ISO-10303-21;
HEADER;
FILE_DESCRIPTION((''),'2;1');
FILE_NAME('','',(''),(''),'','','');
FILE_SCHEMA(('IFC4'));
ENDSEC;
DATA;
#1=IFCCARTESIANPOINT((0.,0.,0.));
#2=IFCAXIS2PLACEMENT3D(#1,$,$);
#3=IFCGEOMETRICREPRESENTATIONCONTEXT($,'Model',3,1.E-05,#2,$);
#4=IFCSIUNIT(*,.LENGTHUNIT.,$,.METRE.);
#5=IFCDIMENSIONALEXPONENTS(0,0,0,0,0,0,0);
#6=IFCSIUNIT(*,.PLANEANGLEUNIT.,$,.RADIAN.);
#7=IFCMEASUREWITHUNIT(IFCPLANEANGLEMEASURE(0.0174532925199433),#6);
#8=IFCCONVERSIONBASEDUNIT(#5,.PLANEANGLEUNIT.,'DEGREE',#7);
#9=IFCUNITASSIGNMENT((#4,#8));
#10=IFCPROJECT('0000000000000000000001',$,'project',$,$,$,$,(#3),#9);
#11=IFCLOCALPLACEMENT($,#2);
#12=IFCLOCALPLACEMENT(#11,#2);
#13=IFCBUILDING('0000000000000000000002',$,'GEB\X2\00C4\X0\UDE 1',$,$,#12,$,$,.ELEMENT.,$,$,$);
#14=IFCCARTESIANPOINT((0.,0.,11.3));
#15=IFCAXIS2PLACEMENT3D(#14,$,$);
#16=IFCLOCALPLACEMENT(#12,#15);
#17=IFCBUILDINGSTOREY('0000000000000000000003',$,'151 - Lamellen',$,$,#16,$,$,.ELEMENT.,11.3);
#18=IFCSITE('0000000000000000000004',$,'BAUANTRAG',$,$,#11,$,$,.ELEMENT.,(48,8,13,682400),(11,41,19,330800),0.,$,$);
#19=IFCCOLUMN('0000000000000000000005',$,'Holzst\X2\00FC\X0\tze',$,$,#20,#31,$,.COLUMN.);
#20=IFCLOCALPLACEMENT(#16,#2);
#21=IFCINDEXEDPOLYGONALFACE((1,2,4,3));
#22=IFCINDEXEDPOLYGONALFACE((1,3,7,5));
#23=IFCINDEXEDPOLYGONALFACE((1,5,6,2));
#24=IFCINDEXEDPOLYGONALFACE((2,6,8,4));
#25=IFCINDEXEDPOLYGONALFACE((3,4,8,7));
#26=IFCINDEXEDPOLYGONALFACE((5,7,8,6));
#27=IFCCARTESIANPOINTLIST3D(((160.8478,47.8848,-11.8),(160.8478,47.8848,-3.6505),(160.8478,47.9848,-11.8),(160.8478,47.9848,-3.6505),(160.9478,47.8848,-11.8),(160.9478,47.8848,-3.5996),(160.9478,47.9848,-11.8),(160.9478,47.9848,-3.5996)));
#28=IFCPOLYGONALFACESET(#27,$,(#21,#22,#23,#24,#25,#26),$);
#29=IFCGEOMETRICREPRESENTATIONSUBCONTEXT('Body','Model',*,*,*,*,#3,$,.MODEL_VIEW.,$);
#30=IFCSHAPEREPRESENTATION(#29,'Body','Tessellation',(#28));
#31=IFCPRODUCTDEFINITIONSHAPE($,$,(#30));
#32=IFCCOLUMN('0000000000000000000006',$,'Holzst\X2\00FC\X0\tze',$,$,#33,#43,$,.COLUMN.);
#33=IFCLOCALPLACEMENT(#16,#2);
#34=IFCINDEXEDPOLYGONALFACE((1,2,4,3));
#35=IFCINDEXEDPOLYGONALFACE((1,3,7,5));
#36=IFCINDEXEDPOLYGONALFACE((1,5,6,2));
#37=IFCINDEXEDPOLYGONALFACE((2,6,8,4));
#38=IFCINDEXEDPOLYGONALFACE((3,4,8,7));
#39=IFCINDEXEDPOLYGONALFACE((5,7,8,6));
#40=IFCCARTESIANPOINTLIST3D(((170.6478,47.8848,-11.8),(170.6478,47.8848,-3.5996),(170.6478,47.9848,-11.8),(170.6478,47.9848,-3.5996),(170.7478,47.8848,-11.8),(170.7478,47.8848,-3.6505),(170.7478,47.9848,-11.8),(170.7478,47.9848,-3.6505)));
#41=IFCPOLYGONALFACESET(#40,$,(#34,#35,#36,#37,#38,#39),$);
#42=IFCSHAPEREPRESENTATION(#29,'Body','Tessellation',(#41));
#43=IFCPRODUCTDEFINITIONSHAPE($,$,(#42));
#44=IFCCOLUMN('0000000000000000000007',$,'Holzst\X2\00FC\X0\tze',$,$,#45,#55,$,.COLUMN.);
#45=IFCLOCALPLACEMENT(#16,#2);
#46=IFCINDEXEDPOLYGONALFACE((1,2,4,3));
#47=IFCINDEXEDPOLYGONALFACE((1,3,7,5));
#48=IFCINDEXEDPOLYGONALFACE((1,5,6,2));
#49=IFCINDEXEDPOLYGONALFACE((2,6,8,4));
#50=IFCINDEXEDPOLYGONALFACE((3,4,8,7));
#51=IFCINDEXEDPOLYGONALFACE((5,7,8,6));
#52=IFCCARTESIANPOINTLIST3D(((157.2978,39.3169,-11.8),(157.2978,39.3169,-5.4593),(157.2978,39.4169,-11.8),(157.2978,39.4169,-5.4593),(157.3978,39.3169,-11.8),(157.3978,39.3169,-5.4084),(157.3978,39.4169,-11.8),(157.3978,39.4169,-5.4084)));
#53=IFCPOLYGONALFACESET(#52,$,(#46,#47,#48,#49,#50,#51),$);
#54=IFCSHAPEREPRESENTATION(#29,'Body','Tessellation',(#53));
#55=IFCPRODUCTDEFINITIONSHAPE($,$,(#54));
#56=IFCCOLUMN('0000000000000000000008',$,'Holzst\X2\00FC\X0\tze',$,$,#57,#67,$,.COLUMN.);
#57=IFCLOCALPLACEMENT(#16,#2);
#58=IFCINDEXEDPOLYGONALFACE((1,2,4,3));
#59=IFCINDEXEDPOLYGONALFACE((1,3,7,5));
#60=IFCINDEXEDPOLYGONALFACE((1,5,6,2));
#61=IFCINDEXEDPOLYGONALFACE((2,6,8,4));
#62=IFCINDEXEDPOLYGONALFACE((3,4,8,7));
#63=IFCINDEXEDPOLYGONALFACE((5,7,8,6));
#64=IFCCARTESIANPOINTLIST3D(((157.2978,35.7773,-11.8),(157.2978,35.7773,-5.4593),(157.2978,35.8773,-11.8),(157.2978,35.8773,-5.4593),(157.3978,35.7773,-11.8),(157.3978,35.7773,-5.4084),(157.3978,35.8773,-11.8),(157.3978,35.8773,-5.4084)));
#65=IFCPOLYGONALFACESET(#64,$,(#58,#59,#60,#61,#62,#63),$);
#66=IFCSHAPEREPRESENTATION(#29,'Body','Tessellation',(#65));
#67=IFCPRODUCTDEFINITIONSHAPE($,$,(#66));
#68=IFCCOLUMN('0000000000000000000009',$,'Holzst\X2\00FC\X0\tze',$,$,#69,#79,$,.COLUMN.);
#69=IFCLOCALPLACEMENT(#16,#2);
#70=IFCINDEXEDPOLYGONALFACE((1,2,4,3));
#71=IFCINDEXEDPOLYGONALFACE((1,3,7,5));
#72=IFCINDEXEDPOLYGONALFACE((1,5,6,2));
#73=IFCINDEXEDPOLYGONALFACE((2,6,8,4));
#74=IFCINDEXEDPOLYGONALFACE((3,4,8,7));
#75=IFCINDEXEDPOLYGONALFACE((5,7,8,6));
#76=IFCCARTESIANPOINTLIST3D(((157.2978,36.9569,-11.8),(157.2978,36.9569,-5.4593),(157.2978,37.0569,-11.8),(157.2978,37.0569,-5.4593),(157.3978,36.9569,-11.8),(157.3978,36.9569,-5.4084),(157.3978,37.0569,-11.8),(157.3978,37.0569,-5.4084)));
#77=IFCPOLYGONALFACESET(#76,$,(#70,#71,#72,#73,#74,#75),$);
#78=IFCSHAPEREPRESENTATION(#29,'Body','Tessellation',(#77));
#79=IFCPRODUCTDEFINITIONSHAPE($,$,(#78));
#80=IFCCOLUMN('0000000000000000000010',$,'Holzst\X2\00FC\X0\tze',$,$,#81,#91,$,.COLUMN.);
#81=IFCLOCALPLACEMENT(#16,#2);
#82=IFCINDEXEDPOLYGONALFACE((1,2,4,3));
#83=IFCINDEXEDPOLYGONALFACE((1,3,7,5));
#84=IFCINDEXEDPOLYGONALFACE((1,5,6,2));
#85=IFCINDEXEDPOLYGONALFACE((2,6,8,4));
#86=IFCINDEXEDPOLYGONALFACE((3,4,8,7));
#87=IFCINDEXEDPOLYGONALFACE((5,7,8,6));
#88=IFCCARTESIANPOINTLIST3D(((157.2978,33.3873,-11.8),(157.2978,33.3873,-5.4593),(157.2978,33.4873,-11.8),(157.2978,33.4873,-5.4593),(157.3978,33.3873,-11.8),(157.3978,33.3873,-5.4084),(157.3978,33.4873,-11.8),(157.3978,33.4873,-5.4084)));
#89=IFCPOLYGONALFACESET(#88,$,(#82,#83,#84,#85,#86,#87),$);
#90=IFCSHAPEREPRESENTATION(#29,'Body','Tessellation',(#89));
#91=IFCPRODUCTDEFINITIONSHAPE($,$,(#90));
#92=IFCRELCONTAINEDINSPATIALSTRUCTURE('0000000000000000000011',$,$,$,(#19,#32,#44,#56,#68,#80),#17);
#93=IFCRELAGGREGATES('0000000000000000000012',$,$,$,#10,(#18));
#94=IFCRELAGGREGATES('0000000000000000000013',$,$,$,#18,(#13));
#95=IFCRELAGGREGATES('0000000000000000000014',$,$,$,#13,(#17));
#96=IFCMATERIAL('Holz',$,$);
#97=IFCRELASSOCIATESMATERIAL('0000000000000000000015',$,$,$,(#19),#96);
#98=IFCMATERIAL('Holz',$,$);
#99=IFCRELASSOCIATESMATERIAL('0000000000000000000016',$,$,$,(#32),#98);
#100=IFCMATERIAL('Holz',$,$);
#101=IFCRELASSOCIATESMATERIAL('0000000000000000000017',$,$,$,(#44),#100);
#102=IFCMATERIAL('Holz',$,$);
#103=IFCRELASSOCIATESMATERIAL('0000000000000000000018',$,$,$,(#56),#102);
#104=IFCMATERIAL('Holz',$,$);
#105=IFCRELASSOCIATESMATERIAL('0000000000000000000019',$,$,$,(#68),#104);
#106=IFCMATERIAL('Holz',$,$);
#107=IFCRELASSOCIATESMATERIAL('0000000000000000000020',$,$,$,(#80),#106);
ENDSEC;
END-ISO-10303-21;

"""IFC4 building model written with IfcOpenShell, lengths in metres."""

from ifc_helpers import new_model, entity, si_unit, converted_unit, frame, frame_2d, origin, origin_with_axes, place, context, subcontext, project, spatial, rectangle, extrude, clip, halfspace, material, element, save


model = new_model("IFC4")

# Units and contexts
model_context = context("Model", 3, precision=1e-05, world=origin())
body_context = subcontext(model_context, "Body", "Model", "MODEL_VIEW")
ifc_project = project(units=[si_unit("LENGTHUNIT", "METRE"), converted_unit("PLANEANGLEUNIT", "DEGREE", entity("IfcPlaneAngleMeasure", 0.0174532925199433), si_unit("PLANEANGLEUNIT", "RADIAN"), dimensions=[0, 0, 0, 0, 0, 0, 0])], contexts=[model_context])

# Site, building, storey
site_placement = place(None, origin())
site = spatial("IfcSite", under=ifc_project, at=site_placement, Name="BAUANTRAG", CompositionType="ELEMENT", RefLatitude=(48, 8, 13, 682400), RefLongitude=(11, 41, 19, 330800), RefElevation=0.0)
building_placement = place(site_placement, origin())
building = spatial("IfcBuilding", under=site, at=building_placement, Name="GEBÄUDE 1", CompositionType="ELEMENT")
storey_placement = place(building_placement, frame((0.0, 0.0, 11.3)))
storey = spatial("IfcBuildingStorey", under=building, at=storey_placement, Name="151 - Lamellen", CompositionType="ELEMENT", Elevation=11.3)

# Columns
ifc_material_1 = material(Name="Holz")
column_1_placement = place(storey_placement, frame((160.9478, 47.8848, -11.8)))
element("IfcColumn", 1, at=column_1_placement, inside=storey, material=ifc_material_1, Name="Holzstütze", PredefinedType="COLUMN", context=body_context, shape_type="Clipping", body=[
    clip(extrude(rectangle(XDim=0.1, YDim=0.1, at=frame_2d((-0.05, 0.05), x_axis=(0.0, 1.0))), origin_with_axes(), (0.0, 0.0, 1.0), 8.2004), halfspace(frame((-0.05, 0.05, 8.175), z_axis=(0.45399, 0.0, -0.891007), x_axis=(0.0, 1.0, 0.0)), True)),
])
ifc_material_2 = material(Name="Holz")
column_2_placement = place(storey_placement, frame((170.7478, 47.8848, -11.8)))
element("IfcColumn", 2, at=column_2_placement, inside=storey, material=ifc_material_2, Name="Holzstütze", PredefinedType="COLUMN", context=body_context, shape_type="Clipping", body=[
    clip(extrude(rectangle(XDim=0.1, YDim=0.1, at=frame_2d((-0.05, 0.05), x_axis=(0.0, 1.0))), origin_with_axes(), (0.0, 0.0, 1.0), 8.2004), halfspace(frame((-0.05, 0.05, 8.175), z_axis=(-0.45399, 0.0, -0.891007), x_axis=(0.0, 1.0, 0.0)), True)),
])
ifc_material_3 = material(Name="Holz")
column_3_placement = place(storey_placement, frame((157.3978, 39.3169, -11.8)))
element("IfcColumn", 3, at=column_3_placement, inside=storey, material=ifc_material_3, Name="Holzstütze", PredefinedType="COLUMN", context=body_context, shape_type="Clipping", body=[
    clip(extrude(rectangle(XDim=0.1, YDim=0.1, at=frame_2d((-0.05, 0.05), x_axis=(0.0, 1.0))), origin_with_axes(), (0.0, 0.0, 1.0), 6.3916), halfspace(frame((-0.05, 0.05, 6.3661), z_axis=(0.45399, 0.0, -0.891007), x_axis=(-0.891007, 0.0, -0.45399)), True)),
])
ifc_material_4 = material(Name="Holz")
column_4_placement = place(storey_placement, frame((157.3978, 35.7773, -11.8)))
element("IfcColumn", 4, at=column_4_placement, inside=storey, material=ifc_material_4, Name="Holzstütze", PredefinedType="COLUMN", context=body_context, shape_type="Clipping", body=[
    clip(extrude(rectangle(XDim=0.1, YDim=0.1, at=frame_2d((-0.05, 0.05), x_axis=(0.0, 1.0))), origin_with_axes(), (0.0, 0.0, 1.0), 6.3916), halfspace(frame((-0.05, 0.05, 6.3661), z_axis=(0.45399, 0.0, -0.891007), x_axis=(-0.891007, 0.0, -0.45399)), True)),
])
ifc_material_5 = material(Name="Holz")
column_5_placement = place(storey_placement, frame((157.3978, 36.9569, -11.8)))
element("IfcColumn", 5, at=column_5_placement, inside=storey, material=ifc_material_5, Name="Holzstütze", PredefinedType="COLUMN", context=body_context, shape_type="Clipping", body=[
    clip(extrude(rectangle(XDim=0.1, YDim=0.1, at=frame_2d((-0.05, 0.05), x_axis=(0.0, 1.0))), origin_with_axes(), (0.0, 0.0, 1.0), 6.3916), halfspace(frame((-0.05, 0.05, 6.3661), z_axis=(0.45399, 0.0, -0.891007), x_axis=(-0.891007, 0.0, -0.45399)), True)),
])
ifc_material_6 = material(Name="Holz")
column_6_placement = place(storey_placement, frame((157.3978, 33.3873, -11.8)))
element("IfcColumn", 6, at=column_6_placement, inside=storey, material=ifc_material_6, Name="Holzstütze", PredefinedType="COLUMN", context=body_context, shape_type="Clipping", body=[
    clip(extrude(rectangle(XDim=0.1, YDim=0.1, at=frame_2d((-0.05, 0.05), x_axis=(0.0, 1.0))), origin_with_axes(), (0.0, 0.0, 1.0), 6.3916), halfspace(frame((-0.05, 0.05, 6.3661), z_axis=(0.45399, 0.0, -0.891007), x_axis=(-0.891007, 0.0, -0.45399)), True)),
])

save(model, "model.ifc")
